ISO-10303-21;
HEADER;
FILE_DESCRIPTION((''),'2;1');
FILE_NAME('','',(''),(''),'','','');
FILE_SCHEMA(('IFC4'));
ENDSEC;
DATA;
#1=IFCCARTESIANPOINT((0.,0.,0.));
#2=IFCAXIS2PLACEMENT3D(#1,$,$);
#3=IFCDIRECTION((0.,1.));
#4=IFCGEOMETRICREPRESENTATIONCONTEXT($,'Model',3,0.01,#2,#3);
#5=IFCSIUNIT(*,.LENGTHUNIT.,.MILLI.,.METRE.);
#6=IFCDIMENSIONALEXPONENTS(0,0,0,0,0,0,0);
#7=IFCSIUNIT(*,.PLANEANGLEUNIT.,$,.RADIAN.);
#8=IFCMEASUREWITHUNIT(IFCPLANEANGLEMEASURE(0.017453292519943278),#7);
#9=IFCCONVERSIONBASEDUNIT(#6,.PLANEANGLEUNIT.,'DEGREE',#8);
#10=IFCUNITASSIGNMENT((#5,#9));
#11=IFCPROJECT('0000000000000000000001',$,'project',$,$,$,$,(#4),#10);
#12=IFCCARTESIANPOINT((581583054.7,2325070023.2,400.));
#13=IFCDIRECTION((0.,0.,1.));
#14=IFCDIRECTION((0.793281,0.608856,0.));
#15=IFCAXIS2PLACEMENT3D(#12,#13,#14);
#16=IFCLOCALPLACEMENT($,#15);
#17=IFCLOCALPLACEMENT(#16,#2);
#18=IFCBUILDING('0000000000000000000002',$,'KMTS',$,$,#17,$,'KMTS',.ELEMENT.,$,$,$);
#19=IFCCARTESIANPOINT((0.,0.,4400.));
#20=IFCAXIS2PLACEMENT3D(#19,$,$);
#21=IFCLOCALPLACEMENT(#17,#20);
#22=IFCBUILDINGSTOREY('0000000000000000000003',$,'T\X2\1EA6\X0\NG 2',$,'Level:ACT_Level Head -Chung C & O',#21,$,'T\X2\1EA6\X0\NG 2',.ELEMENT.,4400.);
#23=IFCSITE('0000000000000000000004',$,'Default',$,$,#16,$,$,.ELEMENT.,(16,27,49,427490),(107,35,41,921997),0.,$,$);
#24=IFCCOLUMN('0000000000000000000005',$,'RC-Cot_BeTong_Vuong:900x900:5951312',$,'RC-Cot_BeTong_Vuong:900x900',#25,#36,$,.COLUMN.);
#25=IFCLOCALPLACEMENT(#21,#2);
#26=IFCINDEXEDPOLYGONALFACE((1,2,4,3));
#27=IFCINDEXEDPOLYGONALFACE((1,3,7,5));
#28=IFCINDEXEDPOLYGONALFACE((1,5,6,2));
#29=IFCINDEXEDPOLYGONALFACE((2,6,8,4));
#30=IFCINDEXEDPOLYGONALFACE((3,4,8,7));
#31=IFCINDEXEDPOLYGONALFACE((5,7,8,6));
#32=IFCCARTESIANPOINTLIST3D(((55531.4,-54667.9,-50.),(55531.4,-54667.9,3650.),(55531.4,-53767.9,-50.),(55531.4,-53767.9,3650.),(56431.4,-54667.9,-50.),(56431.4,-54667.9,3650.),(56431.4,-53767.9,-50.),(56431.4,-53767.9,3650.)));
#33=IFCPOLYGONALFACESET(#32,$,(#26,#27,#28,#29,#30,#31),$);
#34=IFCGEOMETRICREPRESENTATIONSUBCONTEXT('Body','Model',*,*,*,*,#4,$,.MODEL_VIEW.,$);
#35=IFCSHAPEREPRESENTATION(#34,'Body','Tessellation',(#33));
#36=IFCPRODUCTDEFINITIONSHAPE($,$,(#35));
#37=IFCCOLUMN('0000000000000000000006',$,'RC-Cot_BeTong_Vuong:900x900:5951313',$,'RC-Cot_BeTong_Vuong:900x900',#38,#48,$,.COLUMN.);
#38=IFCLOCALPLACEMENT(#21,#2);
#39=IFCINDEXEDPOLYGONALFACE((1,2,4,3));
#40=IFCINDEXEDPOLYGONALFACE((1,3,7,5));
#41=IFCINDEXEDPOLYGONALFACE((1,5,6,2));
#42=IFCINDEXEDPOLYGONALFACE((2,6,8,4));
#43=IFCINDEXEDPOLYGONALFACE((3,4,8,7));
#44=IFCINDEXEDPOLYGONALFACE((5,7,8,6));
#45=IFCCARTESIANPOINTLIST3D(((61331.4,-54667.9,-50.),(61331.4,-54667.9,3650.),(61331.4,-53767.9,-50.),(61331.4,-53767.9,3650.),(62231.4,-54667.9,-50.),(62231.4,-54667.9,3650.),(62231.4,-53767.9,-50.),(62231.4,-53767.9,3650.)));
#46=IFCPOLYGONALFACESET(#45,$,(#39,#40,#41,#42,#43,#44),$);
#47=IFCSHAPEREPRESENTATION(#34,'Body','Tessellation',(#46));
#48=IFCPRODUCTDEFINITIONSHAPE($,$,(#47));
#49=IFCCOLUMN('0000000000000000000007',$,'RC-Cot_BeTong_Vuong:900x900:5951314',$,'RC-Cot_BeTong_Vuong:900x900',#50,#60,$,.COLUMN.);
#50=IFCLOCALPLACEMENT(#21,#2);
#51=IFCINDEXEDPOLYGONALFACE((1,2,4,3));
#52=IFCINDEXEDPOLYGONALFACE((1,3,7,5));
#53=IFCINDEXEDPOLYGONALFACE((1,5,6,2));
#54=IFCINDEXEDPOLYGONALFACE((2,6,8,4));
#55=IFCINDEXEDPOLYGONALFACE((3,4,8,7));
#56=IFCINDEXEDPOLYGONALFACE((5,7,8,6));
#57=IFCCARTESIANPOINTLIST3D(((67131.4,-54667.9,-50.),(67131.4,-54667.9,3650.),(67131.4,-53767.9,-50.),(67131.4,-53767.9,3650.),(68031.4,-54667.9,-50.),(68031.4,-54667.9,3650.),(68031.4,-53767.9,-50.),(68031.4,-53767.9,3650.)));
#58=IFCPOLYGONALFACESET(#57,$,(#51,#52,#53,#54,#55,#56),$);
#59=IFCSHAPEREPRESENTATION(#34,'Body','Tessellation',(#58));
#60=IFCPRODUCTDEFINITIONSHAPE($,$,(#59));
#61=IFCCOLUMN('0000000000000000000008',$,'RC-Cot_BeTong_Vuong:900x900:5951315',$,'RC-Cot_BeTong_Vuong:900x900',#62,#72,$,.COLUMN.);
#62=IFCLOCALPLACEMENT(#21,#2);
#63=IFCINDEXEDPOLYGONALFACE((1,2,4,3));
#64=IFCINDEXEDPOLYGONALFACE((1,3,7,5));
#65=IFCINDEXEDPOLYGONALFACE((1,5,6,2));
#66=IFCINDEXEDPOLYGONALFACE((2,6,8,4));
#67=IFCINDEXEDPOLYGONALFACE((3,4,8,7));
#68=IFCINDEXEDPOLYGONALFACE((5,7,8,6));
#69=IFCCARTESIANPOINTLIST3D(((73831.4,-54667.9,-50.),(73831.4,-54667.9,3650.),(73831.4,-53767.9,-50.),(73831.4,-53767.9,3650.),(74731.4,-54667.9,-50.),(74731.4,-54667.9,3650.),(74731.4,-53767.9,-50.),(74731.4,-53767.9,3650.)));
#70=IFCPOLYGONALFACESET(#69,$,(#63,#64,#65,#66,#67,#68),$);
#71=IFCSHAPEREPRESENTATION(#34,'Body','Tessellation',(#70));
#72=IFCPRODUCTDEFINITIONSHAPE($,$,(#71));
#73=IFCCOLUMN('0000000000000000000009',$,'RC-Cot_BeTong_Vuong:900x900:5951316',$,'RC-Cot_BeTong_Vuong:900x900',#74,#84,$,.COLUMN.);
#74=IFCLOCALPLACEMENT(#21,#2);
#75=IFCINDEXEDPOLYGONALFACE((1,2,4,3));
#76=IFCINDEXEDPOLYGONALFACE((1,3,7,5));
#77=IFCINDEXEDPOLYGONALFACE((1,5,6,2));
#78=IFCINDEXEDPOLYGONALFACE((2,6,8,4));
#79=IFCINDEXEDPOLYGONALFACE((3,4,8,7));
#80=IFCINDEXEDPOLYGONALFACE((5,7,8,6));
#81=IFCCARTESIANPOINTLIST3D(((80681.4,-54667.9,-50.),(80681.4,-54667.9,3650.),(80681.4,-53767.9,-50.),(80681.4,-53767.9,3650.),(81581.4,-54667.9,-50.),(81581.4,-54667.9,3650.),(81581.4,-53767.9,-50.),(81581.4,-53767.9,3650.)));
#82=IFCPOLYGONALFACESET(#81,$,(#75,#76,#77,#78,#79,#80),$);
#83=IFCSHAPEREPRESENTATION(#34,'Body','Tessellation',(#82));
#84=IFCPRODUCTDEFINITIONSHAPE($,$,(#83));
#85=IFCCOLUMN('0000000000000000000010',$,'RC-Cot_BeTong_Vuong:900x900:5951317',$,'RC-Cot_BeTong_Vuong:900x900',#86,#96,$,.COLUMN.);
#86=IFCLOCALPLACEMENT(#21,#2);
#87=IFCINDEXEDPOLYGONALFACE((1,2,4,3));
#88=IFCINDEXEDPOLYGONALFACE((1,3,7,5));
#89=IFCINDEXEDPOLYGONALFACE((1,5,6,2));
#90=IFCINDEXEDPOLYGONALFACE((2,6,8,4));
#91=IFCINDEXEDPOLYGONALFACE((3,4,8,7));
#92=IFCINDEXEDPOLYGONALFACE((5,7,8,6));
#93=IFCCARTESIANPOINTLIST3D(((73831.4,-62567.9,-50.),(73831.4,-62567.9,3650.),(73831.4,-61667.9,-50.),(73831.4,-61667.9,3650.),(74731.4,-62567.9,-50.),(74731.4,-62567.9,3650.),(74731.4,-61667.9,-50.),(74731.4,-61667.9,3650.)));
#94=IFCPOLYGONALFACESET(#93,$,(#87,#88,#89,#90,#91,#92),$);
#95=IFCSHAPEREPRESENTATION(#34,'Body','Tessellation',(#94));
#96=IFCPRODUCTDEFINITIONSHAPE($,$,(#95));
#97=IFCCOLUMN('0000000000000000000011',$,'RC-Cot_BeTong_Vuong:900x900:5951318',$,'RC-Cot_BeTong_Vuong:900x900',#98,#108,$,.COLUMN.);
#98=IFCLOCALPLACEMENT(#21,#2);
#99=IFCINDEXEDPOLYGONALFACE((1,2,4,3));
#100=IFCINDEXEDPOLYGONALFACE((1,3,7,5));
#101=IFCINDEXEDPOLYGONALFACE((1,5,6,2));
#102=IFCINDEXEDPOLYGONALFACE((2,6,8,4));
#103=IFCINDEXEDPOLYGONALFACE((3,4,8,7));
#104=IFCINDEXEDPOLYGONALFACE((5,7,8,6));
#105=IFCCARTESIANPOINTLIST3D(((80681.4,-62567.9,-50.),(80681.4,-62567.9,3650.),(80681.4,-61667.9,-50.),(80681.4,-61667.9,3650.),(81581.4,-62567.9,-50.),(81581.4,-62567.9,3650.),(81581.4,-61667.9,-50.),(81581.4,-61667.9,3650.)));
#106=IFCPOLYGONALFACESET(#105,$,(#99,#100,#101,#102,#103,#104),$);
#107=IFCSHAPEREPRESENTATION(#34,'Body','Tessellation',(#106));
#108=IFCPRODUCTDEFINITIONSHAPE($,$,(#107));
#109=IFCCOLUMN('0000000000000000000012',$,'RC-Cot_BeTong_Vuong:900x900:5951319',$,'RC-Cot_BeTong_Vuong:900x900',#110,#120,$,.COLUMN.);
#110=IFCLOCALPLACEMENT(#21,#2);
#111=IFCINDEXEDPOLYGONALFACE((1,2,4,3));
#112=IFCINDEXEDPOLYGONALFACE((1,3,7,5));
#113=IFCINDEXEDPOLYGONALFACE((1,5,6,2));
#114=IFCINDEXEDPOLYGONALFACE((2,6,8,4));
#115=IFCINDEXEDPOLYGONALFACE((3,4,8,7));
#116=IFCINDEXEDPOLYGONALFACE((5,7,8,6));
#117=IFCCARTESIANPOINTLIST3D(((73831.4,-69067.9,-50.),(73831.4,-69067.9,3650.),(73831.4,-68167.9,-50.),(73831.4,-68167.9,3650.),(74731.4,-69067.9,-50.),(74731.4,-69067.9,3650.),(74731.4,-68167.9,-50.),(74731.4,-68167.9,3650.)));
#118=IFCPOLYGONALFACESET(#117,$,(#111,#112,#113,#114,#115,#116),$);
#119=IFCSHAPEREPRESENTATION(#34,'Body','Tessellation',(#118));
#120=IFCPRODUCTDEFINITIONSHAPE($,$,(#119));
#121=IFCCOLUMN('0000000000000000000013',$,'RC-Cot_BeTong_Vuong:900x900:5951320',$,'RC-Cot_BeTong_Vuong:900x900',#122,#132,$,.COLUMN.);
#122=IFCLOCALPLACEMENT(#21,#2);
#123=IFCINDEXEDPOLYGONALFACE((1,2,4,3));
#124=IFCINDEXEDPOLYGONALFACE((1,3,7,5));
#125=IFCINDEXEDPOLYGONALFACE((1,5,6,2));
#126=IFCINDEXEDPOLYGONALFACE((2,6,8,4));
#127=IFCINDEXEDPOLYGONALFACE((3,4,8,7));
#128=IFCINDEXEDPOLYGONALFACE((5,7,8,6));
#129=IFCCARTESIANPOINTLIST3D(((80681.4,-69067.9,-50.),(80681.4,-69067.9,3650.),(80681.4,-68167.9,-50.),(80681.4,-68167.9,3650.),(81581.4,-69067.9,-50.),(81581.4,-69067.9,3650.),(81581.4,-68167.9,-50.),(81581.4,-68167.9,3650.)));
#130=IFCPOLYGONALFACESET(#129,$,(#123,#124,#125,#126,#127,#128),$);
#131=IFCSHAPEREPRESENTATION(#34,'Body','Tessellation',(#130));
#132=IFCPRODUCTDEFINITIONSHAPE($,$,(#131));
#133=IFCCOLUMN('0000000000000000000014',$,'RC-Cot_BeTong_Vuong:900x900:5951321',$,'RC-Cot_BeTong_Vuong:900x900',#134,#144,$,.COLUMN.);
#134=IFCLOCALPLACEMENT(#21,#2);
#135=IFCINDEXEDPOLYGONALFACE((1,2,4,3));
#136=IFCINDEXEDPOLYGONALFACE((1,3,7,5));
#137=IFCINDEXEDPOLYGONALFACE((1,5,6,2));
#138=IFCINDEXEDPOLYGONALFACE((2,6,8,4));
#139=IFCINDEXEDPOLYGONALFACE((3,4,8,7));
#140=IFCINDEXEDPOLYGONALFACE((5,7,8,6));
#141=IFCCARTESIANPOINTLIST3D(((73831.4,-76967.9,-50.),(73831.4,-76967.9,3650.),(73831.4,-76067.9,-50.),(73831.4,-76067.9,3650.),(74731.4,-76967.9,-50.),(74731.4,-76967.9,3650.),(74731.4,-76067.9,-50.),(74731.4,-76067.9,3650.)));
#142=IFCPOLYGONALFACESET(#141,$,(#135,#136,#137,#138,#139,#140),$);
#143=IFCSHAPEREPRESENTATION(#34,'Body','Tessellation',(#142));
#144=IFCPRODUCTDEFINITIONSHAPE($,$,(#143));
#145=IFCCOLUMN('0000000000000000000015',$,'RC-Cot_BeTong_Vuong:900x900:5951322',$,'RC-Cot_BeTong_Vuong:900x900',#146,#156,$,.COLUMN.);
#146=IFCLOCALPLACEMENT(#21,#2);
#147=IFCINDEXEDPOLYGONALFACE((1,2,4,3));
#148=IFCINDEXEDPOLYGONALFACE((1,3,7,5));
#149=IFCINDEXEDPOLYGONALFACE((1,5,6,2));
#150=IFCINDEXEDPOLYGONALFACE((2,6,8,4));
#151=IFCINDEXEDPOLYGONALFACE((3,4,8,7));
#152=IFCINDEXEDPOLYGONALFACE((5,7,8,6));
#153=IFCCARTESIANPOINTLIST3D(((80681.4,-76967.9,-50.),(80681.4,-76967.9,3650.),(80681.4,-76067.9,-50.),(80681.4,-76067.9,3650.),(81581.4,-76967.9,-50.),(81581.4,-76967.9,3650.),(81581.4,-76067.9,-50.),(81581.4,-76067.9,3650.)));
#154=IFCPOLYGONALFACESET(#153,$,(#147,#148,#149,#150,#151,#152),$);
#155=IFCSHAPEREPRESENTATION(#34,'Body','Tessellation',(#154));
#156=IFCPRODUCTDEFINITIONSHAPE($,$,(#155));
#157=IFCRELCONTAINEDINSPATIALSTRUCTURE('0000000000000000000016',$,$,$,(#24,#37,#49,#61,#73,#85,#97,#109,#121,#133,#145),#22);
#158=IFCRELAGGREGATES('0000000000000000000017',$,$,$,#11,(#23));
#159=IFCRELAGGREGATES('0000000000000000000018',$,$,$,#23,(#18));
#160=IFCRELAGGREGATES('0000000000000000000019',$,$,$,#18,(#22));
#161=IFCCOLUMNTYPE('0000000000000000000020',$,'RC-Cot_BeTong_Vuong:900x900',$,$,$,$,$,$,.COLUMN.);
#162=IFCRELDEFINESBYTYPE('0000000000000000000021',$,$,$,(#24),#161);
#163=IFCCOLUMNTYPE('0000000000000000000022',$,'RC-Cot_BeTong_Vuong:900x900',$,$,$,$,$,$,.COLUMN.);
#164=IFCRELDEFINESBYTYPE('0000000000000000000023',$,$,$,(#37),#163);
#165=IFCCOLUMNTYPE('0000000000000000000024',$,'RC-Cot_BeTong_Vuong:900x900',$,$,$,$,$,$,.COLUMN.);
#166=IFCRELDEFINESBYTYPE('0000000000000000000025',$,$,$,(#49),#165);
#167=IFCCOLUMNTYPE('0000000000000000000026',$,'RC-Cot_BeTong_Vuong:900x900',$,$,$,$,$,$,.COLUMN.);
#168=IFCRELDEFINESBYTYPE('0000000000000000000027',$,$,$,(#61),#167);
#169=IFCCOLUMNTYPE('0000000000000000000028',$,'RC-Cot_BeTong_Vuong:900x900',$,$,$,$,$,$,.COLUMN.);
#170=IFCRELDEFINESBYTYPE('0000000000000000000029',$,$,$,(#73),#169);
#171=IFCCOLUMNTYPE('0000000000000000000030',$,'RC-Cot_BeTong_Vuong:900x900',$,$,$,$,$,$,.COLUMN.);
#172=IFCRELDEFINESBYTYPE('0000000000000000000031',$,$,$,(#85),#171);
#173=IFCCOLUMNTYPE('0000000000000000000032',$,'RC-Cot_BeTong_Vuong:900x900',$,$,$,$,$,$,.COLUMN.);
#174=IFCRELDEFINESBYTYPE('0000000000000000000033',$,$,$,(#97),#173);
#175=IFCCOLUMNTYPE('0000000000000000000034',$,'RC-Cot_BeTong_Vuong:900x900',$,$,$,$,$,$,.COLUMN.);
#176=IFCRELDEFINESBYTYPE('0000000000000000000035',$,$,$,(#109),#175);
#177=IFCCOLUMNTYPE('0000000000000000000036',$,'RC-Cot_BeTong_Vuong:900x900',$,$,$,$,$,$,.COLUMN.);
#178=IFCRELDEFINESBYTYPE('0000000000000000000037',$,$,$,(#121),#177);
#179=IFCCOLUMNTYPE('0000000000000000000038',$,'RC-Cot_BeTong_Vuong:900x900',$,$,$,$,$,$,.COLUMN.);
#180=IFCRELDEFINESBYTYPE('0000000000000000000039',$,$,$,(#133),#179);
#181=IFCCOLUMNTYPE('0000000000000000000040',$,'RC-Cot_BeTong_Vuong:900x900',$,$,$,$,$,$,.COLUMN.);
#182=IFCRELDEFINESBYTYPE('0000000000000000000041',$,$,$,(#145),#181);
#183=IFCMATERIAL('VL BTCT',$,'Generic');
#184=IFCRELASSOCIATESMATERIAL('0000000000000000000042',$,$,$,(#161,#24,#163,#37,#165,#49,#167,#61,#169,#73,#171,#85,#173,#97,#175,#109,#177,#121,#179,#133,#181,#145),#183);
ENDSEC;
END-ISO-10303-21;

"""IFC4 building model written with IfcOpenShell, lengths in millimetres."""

from ifc_helpers import new_model, entity, si_unit, converted_unit, direction, frame, origin, place, context, subcontext, project, spatial, indexed_curve, outline, extrude, source, transform, mapped, material, type_object, type_shapes, element, save


model = new_model("IFC4")

# Units and contexts
model_context = context("Model", 3, precision=0.01, world=origin(), true_north=direction((0.0, 1.0)))
body_context = subcontext(model_context, "Body", "Model", "MODEL_VIEW")
ifc_project = project(units=[si_unit("LENGTHUNIT", "METRE", prefix="MILLI"), converted_unit("PLANEANGLEUNIT", "DEGREE", entity("IfcPlaneAngleMeasure", 0.017453292519943278), si_unit("PLANEANGLEUNIT", "RADIAN"), dimensions=[0, 0, 0, 0, 0, 0, 0])], contexts=[model_context])

# Site, building, storey
site_placement = place(None, frame((581583054.7, 2325070023.2, 400.0), z_axis=(0.0, 0.0, 1.0), x_axis=(0.793281, 0.608856, 0.0)))
site = spatial("IfcSite", under=ifc_project, at=site_placement, Name="Default", CompositionType="ELEMENT", RefLatitude=(16, 27, 49, 427490), RefLongitude=(107, 35, 41, 921997), RefElevation=0.0)
building_placement = place(site_placement, origin())
building = spatial("IfcBuilding", under=site, at=building_placement, Name="KMTS", LongName="KMTS", CompositionType="ELEMENT")
storey_placement = place(building_placement, frame((0.0, 0.0, 4400.0)))
storey = spatial("IfcBuildingStorey", under=building, at=storey_placement, Name="TẦNG 2", ObjectType="Level:ACT_Level Head -Chung C & O", LongName="TẦNG 2", CompositionType="ELEMENT", Elevation=4400.0)

# Columns
ifc_material_1 = material(Name="VL BTCT", Category="Generic")
column_type_1 = type_object("IfcColumnType", Name="RC-Cot_BeTong_Vuong:900x900", PredefinedType="COLUMN", material=ifc_material_1)
shared_shape_1 = source(origin(), body_context, "Body", "SweptSolid", [
    extrude(outline(indexed_curve([(-450.0, -450.0), (450.0, -450.0), (450.0, 450.0), (-450.0, 450.0), (-450.0, -450.0)], self_intersect=False)), frame((55981.4, -54217.9, 4350.0), z_axis=(0.0, 0.0, 1.0), x_axis=(-1.0, 0.0, 0.0)), (0.0, 0.0, 1.0), 3700.0),
])
type_shapes(column_type_1, [shared_shape_1])
column_1_placement = place(storey_placement, frame((0.0, 0.0, -4400.0)))
element("IfcColumn", 1, at=column_1_placement, inside=storey, type_object=column_type_1, material=ifc_material_1, Name="RC-Cot_BeTong_Vuong:900x900:5951312", ObjectType="RC-Cot_BeTong_Vuong:900x900", PredefinedType="COLUMN", context=body_context, shape_type="MappedRepresentation", body=[
    mapped(shared_shape_1, transform((0.0, 0.0, 0.0), scale=1.0)),
])
column_type_2 = type_object("IfcColumnType", Name="RC-Cot_BeTong_Vuong:900x900", PredefinedType="COLUMN", material=ifc_material_1)
shared_shape_2 = source(origin(), body_context, "Body", "SweptSolid", [
    extrude(outline(indexed_curve([(-450.0, -450.0), (450.0, -450.0), (450.0, 450.0), (-450.0, 450.0), (-450.0, -450.0)], self_intersect=False)), frame((61781.4, -54217.9, 4350.0), z_axis=(0.0, 0.0, 1.0), x_axis=(-1.0, 0.0, 0.0)), (0.0, 0.0, 1.0), 3700.0),
])
type_shapes(column_type_2, [shared_shape_2])
column_2_placement = place(storey_placement, frame((0.0, 0.0, -4400.0)))
element("IfcColumn", 2, at=column_2_placement, inside=storey, type_object=column_type_2, material=ifc_material_1, Name="RC-Cot_BeTong_Vuong:900x900:5951313", ObjectType="RC-Cot_BeTong_Vuong:900x900", PredefinedType="COLUMN", context=body_context, shape_type="MappedRepresentation", body=[
    mapped(shared_shape_2, transform((0.0, 0.0, 0.0), scale=1.0)),
])
column_type_3 = type_object("IfcColumnType", Name="RC-Cot_BeTong_Vuong:900x900", PredefinedType="COLUMN", material=ifc_material_1)
shared_shape_3 = source(origin(), body_context, "Body", "SweptSolid", [
    extrude(outline(indexed_curve([(-450.0, -450.0), (450.0, -450.0), (450.0, 450.0), (-450.0, 450.0), (-450.0, -450.0)], self_intersect=False)), frame((67581.4, -54217.9, 4350.0), z_axis=(0.0, 0.0, 1.0), x_axis=(-1.0, 0.0, 0.0)), (0.0, 0.0, 1.0), 3700.0),
])
type_shapes(column_type_3, [shared_shape_3])
column_3_placement = place(storey_placement, frame((0.0, 0.0, -4400.0)))
element("IfcColumn", 3, at=column_3_placement, inside=storey, type_object=column_type_3, material=ifc_material_1, Name="RC-Cot_BeTong_Vuong:900x900:5951314", ObjectType="RC-Cot_BeTong_Vuong:900x900", PredefinedType="COLUMN", context=body_context, shape_type="MappedRepresentation", body=[
    mapped(shared_shape_3, transform((0.0, 0.0, 0.0), scale=1.0)),
])
column_type_4 = type_object("IfcColumnType", Name="RC-Cot_BeTong_Vuong:900x900", PredefinedType="COLUMN", material=ifc_material_1)
shared_shape_4 = source(origin(), body_context, "Body", "SweptSolid", [
    extrude(outline(indexed_curve([(-450.0, -450.0), (450.0, -450.0), (450.0, 450.0), (-450.0, 450.0), (-450.0, -450.0)], self_intersect=False)), frame((74281.4, -54217.9, 4350.0), z_axis=(0.0, 0.0, 1.0), x_axis=(-1.0, 0.0, 0.0)), (0.0, 0.0, 1.0), 3700.0),
])
type_shapes(column_type_4, [shared_shape_4])
column_4_placement = place(storey_placement, frame((0.0, 0.0, -4400.0)))
element("IfcColumn", 4, at=column_4_placement, inside=storey, type_object=column_type_4, material=ifc_material_1, Name="RC-Cot_BeTong_Vuong:900x900:5951315", ObjectType="RC-Cot_BeTong_Vuong:900x900", PredefinedType="COLUMN", context=body_context, shape_type="MappedRepresentation", body=[
    mapped(shared_shape_4, transform((0.0, 0.0, 0.0), scale=1.0)),
])
column_type_5 = type_object("IfcColumnType", Name="RC-Cot_BeTong_Vuong:900x900", PredefinedType="COLUMN", material=ifc_material_1)
shared_shape_5 = source(origin(), body_context, "Body", "SweptSolid", [
    extrude(outline(indexed_curve([(-450.0, -450.0), (450.0, -450.0), (450.0, 450.0), (-450.0, 450.0), (-450.0, -450.0)], self_intersect=False)), frame((81131.4, -54217.9, 4350.0), z_axis=(0.0, 0.0, 1.0), x_axis=(-1.0, 0.0, 0.0)), (0.0, 0.0, 1.0), 3700.0),
])
type_shapes(column_type_5, [shared_shape_5])
column_5_placement = place(storey_placement, frame((0.0, 0.0, -4400.0)))
element("IfcColumn", 5, at=column_5_placement, inside=storey, type_object=column_type_5, material=ifc_material_1, Name="RC-Cot_BeTong_Vuong:900x900:5951316", ObjectType="RC-Cot_BeTong_Vuong:900x900", PredefinedType="COLUMN", context=body_context, shape_type="MappedRepresentation", body=[
    mapped(shared_shape_5, transform((0.0, 0.0, 0.0), scale=1.0)),
])
column_type_6 = type_object("IfcColumnType", Name="RC-Cot_BeTong_Vuong:900x900", PredefinedType="COLUMN", material=ifc_material_1)
shared_shape_6 = source(origin(), body_context, "Body", "SweptSolid", [
    extrude(outline(indexed_curve([(-450.0, -450.0), (450.0, -450.0), (450.0, 450.0), (-450.0, 450.0), (-450.0, -450.0)], self_intersect=False)), frame((74281.4, -62117.9, 4350.0), z_axis=(0.0, 0.0, 1.0), x_axis=(-1.0, 0.0, 0.0)), (0.0, 0.0, 1.0), 3700.0),
])
type_shapes(column_type_6, [shared_shape_6])
column_6_placement = place(storey_placement, frame((0.0, 0.0, -4400.0)))
element("IfcColumn", 6, at=column_6_placement, inside=storey, type_object=column_type_6, material=ifc_material_1, Name="RC-Cot_BeTong_Vuong:900x900:5951317", ObjectType="RC-Cot_BeTong_Vuong:900x900", PredefinedType="COLUMN", context=body_context, shape_type="MappedRepresentation", body=[
    mapped(shared_shape_6, transform((0.0, 0.0, 0.0), scale=1.0)),
])
column_type_7 = type_object("IfcColumnType", Name="RC-Cot_BeTong_Vuong:900x900", PredefinedType="COLUMN", material=ifc_material_1)
shared_shape_7 = source(origin(), body_context, "Body", "SweptSolid", [
    extrude(outline(indexed_curve([(-450.0, -450.0), (450.0, -450.0), (450.0, 450.0), (-450.0, 450.0), (-450.0, -450.0)], self_intersect=False)), frame((81131.4, -62117.9, 4350.0), z_axis=(0.0, 0.0, 1.0), x_axis=(-1.0, 0.0, 0.0)), (0.0, 0.0, 1.0), 3700.0),
])
type_shapes(column_type_7, [shared_shape_7])
column_7_placement = place(storey_placement, frame((0.0, 0.0, -4400.0)))
element("IfcColumn", 7, at=column_7_placement, inside=storey, type_object=column_type_7, material=ifc_material_1, Name="RC-Cot_BeTong_Vuong:900x900:5951318", ObjectType="RC-Cot_BeTong_Vuong:900x900", PredefinedType="COLUMN", context=body_context, shape_type="MappedRepresentation", body=[
    mapped(shared_shape_7, transform((0.0, 0.0, 0.0), scale=1.0)),
])
column_type_8 = type_object("IfcColumnType", Name="RC-Cot_BeTong_Vuong:900x900", PredefinedType="COLUMN", material=ifc_material_1)
shared_shape_8 = source(origin(), body_context, "Body", "SweptSolid", [
    extrude(outline(indexed_curve([(-450.0, -450.0), (450.0, -450.0), (450.0, 450.0), (-450.0, 450.0), (-450.0, -450.0)], self_intersect=False)), frame((74281.4, -68617.9, 4350.0), z_axis=(0.0, 0.0, 1.0), x_axis=(-1.0, 0.0, 0.0)), (0.0, 0.0, 1.0), 3700.0),
])
type_shapes(column_type_8, [shared_shape_8])
column_8_placement = place(storey_placement, frame((0.0, 0.0, -4400.0)))
element("IfcColumn", 8, at=column_8_placement, inside=storey, type_object=column_type_8, material=ifc_material_1, Name="RC-Cot_BeTong_Vuong:900x900:5951319", ObjectType="RC-Cot_BeTong_Vuong:900x900", PredefinedType="COLUMN", context=body_context, shape_type="MappedRepresentation", body=[
    mapped(shared_shape_8, transform((0.0, 0.0, 0.0), scale=1.0)),
])
column_type_9 = type_object("IfcColumnType", Name="RC-Cot_BeTong_Vuong:900x900", PredefinedType="COLUMN", material=ifc_material_1)
shared_shape_9 = source(origin(), body_context, "Body", "SweptSolid", [
    extrude(outline(indexed_curve([(-450.0, -450.0), (450.0, -450.0), (450.0, 450.0), (-450.0, 450.0), (-450.0, -450.0)], self_intersect=False)), frame((81131.4, -68617.9, 4350.0), z_axis=(0.0, 0.0, 1.0), x_axis=(-1.0, 0.0, 0.0)), (0.0, 0.0, 1.0), 3700.0),
])
type_shapes(column_type_9, [shared_shape_9])
column_9_placement = place(storey_placement, frame((0.0, 0.0, -4400.0)))
element("IfcColumn", 9, at=column_9_placement, inside=storey, type_object=column_type_9, material=ifc_material_1, Name="RC-Cot_BeTong_Vuong:900x900:5951320", ObjectType="RC-Cot_BeTong_Vuong:900x900", PredefinedType="COLUMN", context=body_context, shape_type="MappedRepresentation", body=[
    mapped(shared_shape_9, transform((0.0, 0.0, 0.0), scale=1.0)),
])
column_type_10 = type_object("IfcColumnType", Name="RC-Cot_BeTong_Vuong:900x900", PredefinedType="COLUMN", material=ifc_material_1)
shared_shape_10 = source(origin(), body_context, "Body", "SweptSolid", [
    extrude(outline(indexed_curve([(-450.0, -450.0), (450.0, -450.0), (450.0, 450.0), (-450.0, 450.0), (-450.0, -450.0)], self_intersect=False)), frame((74281.4, -76517.9, 4350.0), z_axis=(0.0, 0.0, 1.0), x_axis=(-1.0, 0.0, 0.0)), (0.0, 0.0, 1.0), 3700.0),
])
type_shapes(column_type_10, [shared_shape_10])
column_10_placement = place(storey_placement, frame((0.0, 0.0, -4400.0)))
element("IfcColumn", 10, at=column_10_placement, inside=storey, type_object=column_type_10, material=ifc_material_1, Name="RC-Cot_BeTong_Vuong:900x900:5951321", ObjectType="RC-Cot_BeTong_Vuong:900x900", PredefinedType="COLUMN", context=body_context, shape_type="MappedRepresentation", body=[
    mapped(shared_shape_10, transform((0.0, 0.0, 0.0), scale=1.0)),
])
column_type_11 = type_object("IfcColumnType", Name="RC-Cot_BeTong_Vuong:900x900", PredefinedType="COLUMN", material=ifc_material_1)
shared_shape_11 = source(origin(), body_context, "Body", "SweptSolid", [
    extrude(outline(indexed_curve([(-450.0, -450.0), (450.0, -450.0), (450.0, 450.0), (-450.0, 450.0), (-450.0, -450.0)], self_intersect=False)), frame((81131.4, -76517.9, 4350.0), z_axis=(0.0, 0.0, 1.0), x_axis=(-1.0, 0.0, 0.0)), (0.0, 0.0, 1.0), 3700.0),
])
type_shapes(column_type_11, [shared_shape_11])
column_11_placement = place(storey_placement, frame((0.0, 0.0, -4400.0)))
element("IfcColumn", 11, at=column_11_placement, inside=storey, type_object=column_type_11, material=ifc_material_1, Name="RC-Cot_BeTong_Vuong:900x900:5951322", ObjectType="RC-Cot_BeTong_Vuong:900x900", PredefinedType="COLUMN", context=body_context, shape_type="MappedRepresentation", body=[
    mapped(shared_shape_11, transform((0.0, 0.0, 0.0), scale=1.0)),
])

save(model, "model.ifc")
